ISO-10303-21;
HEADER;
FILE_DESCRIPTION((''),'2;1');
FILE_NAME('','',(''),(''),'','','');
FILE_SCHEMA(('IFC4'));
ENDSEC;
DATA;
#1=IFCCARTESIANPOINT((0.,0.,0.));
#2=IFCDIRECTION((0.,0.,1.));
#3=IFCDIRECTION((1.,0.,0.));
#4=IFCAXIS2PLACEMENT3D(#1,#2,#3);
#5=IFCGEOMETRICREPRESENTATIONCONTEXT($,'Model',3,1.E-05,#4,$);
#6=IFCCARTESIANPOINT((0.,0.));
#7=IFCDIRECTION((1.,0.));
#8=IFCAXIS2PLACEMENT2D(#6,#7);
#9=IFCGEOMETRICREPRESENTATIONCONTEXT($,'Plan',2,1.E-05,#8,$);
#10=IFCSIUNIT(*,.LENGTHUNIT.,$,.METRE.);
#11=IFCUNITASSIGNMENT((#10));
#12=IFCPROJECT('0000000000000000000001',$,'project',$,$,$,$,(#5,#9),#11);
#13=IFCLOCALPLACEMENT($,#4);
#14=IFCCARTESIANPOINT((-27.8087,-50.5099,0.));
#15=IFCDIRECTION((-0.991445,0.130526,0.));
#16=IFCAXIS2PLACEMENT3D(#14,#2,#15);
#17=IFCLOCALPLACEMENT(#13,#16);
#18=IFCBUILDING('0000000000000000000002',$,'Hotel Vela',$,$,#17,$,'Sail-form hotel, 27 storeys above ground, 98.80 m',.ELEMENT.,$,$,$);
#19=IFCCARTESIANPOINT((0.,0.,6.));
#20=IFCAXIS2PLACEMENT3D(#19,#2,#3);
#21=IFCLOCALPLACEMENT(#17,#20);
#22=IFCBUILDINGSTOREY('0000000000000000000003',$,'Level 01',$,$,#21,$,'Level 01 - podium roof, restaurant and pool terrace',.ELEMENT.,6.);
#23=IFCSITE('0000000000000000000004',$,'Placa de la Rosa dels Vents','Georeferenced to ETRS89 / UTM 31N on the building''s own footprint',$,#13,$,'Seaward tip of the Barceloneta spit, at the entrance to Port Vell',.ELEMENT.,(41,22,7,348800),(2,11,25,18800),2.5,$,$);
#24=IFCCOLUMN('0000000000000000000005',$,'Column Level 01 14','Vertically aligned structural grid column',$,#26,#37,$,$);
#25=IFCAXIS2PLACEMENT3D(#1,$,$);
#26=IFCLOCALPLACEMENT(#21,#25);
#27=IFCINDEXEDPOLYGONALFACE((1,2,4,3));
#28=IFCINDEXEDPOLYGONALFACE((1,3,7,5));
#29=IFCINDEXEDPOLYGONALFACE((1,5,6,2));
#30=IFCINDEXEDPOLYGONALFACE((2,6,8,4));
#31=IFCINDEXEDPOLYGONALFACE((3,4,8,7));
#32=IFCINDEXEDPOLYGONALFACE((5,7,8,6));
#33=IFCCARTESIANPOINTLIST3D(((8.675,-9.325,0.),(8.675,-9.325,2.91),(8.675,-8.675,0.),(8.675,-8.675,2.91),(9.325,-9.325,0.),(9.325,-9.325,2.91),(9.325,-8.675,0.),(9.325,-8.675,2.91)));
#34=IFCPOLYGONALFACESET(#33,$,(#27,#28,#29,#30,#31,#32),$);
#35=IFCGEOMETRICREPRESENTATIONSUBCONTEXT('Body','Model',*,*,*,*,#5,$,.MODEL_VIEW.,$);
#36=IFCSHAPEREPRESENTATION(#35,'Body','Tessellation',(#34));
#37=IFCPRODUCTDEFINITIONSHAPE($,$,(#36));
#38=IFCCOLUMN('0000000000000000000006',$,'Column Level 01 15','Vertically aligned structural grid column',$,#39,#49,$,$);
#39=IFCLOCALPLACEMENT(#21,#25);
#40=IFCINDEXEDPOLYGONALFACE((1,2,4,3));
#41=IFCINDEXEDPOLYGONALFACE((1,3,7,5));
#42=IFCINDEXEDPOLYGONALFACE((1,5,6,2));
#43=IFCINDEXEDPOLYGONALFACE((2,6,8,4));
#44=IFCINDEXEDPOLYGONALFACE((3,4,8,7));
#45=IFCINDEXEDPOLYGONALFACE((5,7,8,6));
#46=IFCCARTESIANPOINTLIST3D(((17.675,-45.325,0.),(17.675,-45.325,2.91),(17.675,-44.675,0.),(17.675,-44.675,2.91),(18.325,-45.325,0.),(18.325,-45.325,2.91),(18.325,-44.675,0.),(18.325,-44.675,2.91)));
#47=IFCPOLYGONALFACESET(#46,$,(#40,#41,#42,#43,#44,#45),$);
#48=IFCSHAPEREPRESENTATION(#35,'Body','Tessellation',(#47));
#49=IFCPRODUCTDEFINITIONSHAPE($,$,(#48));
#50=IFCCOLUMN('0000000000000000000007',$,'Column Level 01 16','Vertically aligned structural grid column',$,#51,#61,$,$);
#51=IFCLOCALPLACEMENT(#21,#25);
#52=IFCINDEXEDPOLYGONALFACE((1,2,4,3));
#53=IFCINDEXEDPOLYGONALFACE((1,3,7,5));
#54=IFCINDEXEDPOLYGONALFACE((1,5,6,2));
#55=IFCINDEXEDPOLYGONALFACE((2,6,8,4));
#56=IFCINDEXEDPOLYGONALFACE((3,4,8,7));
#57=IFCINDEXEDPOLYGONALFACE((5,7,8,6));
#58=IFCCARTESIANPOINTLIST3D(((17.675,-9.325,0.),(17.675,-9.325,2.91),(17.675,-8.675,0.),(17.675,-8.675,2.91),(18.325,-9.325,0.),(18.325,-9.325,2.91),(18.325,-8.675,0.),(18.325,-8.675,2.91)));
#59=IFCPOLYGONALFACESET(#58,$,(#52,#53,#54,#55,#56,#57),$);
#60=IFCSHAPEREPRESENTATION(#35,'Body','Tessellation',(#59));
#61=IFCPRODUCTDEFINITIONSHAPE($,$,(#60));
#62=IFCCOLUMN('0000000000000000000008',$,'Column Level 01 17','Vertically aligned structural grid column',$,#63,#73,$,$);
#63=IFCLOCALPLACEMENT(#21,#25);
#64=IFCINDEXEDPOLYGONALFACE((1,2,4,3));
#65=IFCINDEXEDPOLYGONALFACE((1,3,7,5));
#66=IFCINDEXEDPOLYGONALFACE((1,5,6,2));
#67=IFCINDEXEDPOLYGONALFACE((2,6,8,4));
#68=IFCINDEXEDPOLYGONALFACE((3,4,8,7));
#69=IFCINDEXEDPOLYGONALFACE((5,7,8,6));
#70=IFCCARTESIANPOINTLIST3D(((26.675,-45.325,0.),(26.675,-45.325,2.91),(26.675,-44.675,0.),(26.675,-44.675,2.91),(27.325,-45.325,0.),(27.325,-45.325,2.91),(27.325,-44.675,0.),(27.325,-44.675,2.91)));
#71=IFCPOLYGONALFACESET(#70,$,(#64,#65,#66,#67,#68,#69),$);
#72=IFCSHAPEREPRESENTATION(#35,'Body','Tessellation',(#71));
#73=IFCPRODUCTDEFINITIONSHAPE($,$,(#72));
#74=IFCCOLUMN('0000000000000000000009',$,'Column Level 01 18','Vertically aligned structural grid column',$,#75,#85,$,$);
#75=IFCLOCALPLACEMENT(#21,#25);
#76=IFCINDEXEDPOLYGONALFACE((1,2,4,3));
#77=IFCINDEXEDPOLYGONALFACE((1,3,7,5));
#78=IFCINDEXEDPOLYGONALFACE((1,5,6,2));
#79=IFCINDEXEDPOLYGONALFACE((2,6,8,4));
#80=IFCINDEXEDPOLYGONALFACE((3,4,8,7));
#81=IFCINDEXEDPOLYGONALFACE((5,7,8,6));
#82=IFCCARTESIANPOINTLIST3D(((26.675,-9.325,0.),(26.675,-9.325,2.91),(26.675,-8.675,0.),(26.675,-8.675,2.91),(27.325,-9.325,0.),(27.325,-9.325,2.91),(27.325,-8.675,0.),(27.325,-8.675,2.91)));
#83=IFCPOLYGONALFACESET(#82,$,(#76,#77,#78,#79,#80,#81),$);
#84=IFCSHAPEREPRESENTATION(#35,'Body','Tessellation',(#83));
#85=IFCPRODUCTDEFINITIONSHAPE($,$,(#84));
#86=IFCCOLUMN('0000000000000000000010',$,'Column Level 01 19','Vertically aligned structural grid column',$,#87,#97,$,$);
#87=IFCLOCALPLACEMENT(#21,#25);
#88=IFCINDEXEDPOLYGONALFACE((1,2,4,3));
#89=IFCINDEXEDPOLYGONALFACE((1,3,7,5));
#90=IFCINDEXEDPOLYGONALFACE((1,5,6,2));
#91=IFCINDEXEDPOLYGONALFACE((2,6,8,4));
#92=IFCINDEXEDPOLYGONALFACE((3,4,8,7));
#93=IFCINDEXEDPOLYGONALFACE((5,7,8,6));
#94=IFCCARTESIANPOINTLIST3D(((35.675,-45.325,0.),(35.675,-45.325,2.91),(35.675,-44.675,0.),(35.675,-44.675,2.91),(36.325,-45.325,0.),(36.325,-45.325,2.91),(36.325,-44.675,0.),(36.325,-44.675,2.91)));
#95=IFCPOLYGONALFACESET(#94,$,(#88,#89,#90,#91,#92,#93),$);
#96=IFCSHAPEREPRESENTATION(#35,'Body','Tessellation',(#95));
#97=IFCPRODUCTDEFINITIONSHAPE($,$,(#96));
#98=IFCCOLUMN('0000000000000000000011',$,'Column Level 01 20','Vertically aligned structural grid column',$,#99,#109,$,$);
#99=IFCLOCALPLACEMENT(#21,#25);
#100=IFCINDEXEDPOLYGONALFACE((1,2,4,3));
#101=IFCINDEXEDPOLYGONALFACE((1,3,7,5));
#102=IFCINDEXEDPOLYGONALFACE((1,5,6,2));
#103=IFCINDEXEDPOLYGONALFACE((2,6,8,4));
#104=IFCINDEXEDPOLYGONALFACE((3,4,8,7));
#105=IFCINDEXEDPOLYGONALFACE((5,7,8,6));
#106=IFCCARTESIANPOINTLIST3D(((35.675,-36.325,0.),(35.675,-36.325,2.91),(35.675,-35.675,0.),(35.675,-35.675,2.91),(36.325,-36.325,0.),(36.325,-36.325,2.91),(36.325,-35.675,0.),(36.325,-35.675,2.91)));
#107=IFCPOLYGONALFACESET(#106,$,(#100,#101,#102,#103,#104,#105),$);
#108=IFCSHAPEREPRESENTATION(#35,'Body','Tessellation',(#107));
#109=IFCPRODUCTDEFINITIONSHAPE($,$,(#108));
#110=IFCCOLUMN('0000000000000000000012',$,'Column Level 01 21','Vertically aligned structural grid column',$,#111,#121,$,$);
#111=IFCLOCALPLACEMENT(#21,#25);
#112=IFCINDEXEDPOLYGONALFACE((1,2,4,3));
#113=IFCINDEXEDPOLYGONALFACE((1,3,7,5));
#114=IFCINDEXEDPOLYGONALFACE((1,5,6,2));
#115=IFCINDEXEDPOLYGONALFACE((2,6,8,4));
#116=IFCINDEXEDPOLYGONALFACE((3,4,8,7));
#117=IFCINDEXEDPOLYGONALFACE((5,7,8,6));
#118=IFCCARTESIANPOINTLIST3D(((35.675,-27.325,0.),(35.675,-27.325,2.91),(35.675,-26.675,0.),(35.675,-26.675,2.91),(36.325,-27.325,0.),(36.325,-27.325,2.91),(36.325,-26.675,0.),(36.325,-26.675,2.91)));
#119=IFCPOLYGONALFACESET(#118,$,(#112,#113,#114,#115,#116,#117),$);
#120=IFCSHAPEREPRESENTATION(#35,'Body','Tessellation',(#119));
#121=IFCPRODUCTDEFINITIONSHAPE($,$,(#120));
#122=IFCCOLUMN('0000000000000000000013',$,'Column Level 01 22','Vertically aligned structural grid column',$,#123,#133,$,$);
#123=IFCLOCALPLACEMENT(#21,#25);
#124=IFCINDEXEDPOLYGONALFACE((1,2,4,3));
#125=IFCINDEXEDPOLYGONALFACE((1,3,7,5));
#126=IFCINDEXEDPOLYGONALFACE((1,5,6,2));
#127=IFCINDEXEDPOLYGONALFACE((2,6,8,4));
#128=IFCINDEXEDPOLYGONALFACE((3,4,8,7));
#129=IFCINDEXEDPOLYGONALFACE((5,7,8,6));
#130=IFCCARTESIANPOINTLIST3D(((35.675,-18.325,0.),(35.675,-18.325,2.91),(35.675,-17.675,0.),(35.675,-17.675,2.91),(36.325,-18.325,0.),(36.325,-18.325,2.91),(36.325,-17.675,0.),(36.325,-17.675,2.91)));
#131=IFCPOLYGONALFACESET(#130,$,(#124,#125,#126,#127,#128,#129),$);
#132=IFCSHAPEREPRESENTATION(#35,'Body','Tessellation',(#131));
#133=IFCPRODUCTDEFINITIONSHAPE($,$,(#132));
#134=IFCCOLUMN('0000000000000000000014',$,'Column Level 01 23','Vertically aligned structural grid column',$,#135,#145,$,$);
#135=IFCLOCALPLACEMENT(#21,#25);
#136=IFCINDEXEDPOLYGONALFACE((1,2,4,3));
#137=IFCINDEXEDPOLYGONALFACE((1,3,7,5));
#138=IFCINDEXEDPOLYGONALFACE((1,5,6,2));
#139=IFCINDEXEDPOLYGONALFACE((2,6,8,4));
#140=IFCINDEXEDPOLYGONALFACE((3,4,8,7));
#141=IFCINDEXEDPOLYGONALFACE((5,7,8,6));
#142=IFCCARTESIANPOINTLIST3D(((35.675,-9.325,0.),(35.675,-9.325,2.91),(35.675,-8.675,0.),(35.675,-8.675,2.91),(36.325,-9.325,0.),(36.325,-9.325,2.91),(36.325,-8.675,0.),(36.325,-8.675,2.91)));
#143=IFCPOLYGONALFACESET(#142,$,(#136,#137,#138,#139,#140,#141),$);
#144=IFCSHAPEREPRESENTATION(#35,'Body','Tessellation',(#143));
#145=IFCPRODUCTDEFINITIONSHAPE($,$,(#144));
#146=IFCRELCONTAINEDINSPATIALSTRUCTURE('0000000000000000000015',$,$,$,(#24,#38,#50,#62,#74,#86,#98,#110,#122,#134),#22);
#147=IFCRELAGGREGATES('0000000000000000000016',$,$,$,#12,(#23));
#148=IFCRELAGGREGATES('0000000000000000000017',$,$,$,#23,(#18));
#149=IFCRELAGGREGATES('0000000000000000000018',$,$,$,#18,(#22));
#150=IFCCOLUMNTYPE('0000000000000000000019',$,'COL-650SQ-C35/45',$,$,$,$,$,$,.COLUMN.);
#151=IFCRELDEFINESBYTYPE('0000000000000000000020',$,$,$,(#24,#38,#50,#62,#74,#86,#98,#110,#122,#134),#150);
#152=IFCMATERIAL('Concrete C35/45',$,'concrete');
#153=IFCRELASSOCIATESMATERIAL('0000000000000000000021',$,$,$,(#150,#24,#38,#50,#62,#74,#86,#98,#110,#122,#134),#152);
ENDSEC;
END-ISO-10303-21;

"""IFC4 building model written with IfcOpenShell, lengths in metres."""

from ifc_helpers import new_model, si_unit, frame, origin_with_axes, origin_2d_with_axis, place, context, subcontext, project, spatial, line, indexed_curve, rectangle, outline, extrude, material, material_profile, profile_set, profile_usage, type_object, element, save


model = new_model("IFC4")

# Units and contexts
model_context = context("Model", 3, precision=1e-05, world=origin_with_axes())
plan_context = context("Plan", 2, precision=1e-05, world=origin_2d_with_axis())
body_context = subcontext(model_context, "Body", "Model", "MODEL_VIEW")
ifc_project = project(units=[si_unit("LENGTHUNIT", "METRE")], contexts=[model_context, plan_context])

# Site, building, storey
site_placement = place(None, origin_with_axes())
site = spatial("IfcSite", under=ifc_project, at=site_placement, Name="Placa de la Rosa dels Vents", Description="Georeferenced to ETRS89 / UTM 31N on the building's own footprint", LongName="Seaward tip of the Barceloneta spit, at the entrance to Port Vell", CompositionType="ELEMENT", RefLatitude=(41, 22, 7, 348800), RefLongitude=(2, 11, 25, 18800), RefElevation=2.5)
building_placement = place(site_placement, frame((-27.8087, -50.5099, 0.0), z_axis=(0.0, 0.0, 1.0), x_axis=(-0.991445, 0.130526, 0.0)))
building = spatial("IfcBuilding", under=site, at=building_placement, Name="Hotel Vela", LongName="Sail-form hotel, 27 storeys above ground, 98.80 m", CompositionType="ELEMENT")
storey_placement = place(building_placement, frame((0.0, 0.0, 6.0), z_axis=(0.0, 0.0, 1.0), x_axis=(1.0, 0.0, 0.0)))
storey = spatial("IfcBuildingStorey", under=building, at=storey_placement, Name="Level 01", LongName="Level 01 - podium roof, restaurant and pool terrace", CompositionType="ELEMENT", Elevation=6.0)

# Columns
ifc_material = material(Name="Concrete C35/45", Category="concrete")
ifc_material_profile = material_profile(ifc_material, rectangle(XDim=0.65, YDim=0.65))
ifc_profile_set = profile_set([ifc_material_profile], Name="COL-650SQ-C35/45")
column_type = type_object("IfcColumnType", Name="COL-650SQ-C35/45", PredefinedType="COLUMN", material=ifc_profile_set)
ifc_profile_usage_1 = profile_usage(ifc_profile_set)
column_1_placement = place(storey_placement, frame((8.675, -9.325, 0.0), z_axis=(0.0, 0.0, 1.0), x_axis=(1.0, 0.0, 0.0)))
element("IfcColumn", 1, at=column_1_placement, inside=storey, type_object=column_type, material=ifc_profile_usage_1, Name="Column Level 01 14", Description="Vertically aligned structural grid column", context=body_context, shape_type="SweptSolid", body=[
    extrude(outline(indexed_curve([(0.0, 0.0), (0.65, 0.0), (0.65, 0.65), (0.0, 0.65)], segments=[line(1, 2, 3, 4, 1)])), origin_with_axes(), (0.0, 0.0, 1.0), 2.91),
])
ifc_profile_usage_2 = profile_usage(ifc_profile_set)
column_2_placement = place(storey_placement, frame((17.675, -45.325, 0.0), z_axis=(0.0, 0.0, 1.0), x_axis=(1.0, 0.0, 0.0)))
element("IfcColumn", 2, at=column_2_placement, inside=storey, type_object=column_type, material=ifc_profile_usage_2, Name="Column Level 01 15", Description="Vertically aligned structural grid column", context=body_context, shape_type="SweptSolid", body=[
    extrude(outline(indexed_curve([(0.0, 0.0), (0.65, 0.0), (0.65, 0.65), (0.0, 0.65)], segments=[line(1, 2, 3, 4, 1)])), origin_with_axes(), (0.0, 0.0, 1.0), 2.91),
])
ifc_profile_usage_3 = profile_usage(ifc_profile_set)
column_3_placement = place(storey_placement, frame((17.675, -9.325, 0.0), z_axis=(0.0, 0.0, 1.0), x_axis=(1.0, 0.0, 0.0)))
element("IfcColumn", 3, at=column_3_placement, inside=storey, type_object=column_type, material=ifc_profile_usage_3, Name="Column Level 01 16", Description="Vertically aligned structural grid column", context=body_context, shape_type="SweptSolid", body=[
    extrude(outline(indexed_curve([(0.0, 0.0), (0.65, 0.0), (0.65, 0.65), (0.0, 0.65)], segments=[line(1, 2, 3, 4, 1)])), origin_with_axes(), (0.0, 0.0, 1.0), 2.91),
])
ifc_profile_usage_4 = profile_usage(ifc_profile_set)
column_4_placement = place(storey_placement, frame((26.675, -45.325, 0.0), z_axis=(0.0, 0.0, 1.0), x_axis=(1.0, 0.0, 0.0)))
element("IfcColumn", 4, at=column_4_placement, inside=storey, type_object=column_type, material=ifc_profile_usage_4, Name="Column Level 01 17", Description="Vertically aligned structural grid column", context=body_context, shape_type="SweptSolid", body=[
    extrude(outline(indexed_curve([(0.0, 0.0), (0.65, 0.0), (0.65, 0.65), (0.0, 0.65)], segments=[line(1, 2, 3, 4, 1)])), origin_with_axes(), (0.0, 0.0, 1.0), 2.91),
])
ifc_profile_usage_5 = profile_usage(ifc_profile_set)
column_5_placement = place(storey_placement, frame((26.675, -9.325, 0.0), z_axis=(0.0, 0.0, 1.0), x_axis=(1.0, 0.0, 0.0)))
element("IfcColumn", 5, at=column_5_placement, inside=storey, type_object=column_type, material=ifc_profile_usage_5, Name="Column Level 01 18", Description="Vertically aligned structural grid column", context=body_context, shape_type="SweptSolid", body=[
    extrude(outline(indexed_curve([(0.0, 0.0), (0.65, 0.0), (0.65, 0.65), (0.0, 0.65)], segments=[line(1, 2, 3, 4, 1)])), origin_with_axes(), (0.0, 0.0, 1.0), 2.91),
])
ifc_profile_usage_6 = profile_usage(ifc_profile_set)
column_6_placement = place(storey_placement, frame((35.675, -45.325, 0.0), z_axis=(0.0, 0.0, 1.0), x_axis=(1.0, 0.0, 0.0)))
element("IfcColumn", 6, at=column_6_placement, inside=storey, type_object=column_type, material=ifc_profile_usage_6, Name="Column Level 01 19", Description="Vertically aligned structural grid column", context=body_context, shape_type="SweptSolid", body=[
    extrude(outline(indexed_curve([(0.0, 0.0), (0.65, 0.0), (0.65, 0.65), (0.0, 0.65)], segments=[line(1, 2, 3, 4, 1)])), origin_with_axes(), (0.0, 0.0, 1.0), 2.91),
])
ifc_profile_usage_7 = profile_usage(ifc_profile_set)
column_7_placement = place(storey_placement, frame((35.675, -36.325, 0.0), z_axis=(0.0, 0.0, 1.0), x_axis=(1.0, 0.0, 0.0)))
element("IfcColumn", 7, at=column_7_placement, inside=storey, type_object=column_type, material=ifc_profile_usage_7, Name="Column Level 01 20", Description="Vertically aligned structural grid column", context=body_context, shape_type="SweptSolid", body=[
    extrude(outline(indexed_curve([(0.0, 0.0), (0.65, 0.0), (0.65, 0.65), (0.0, 0.65)], segments=[line(1, 2, 3, 4, 1)])), origin_with_axes(), (0.0, 0.0, 1.0), 2.91),
])
ifc_profile_usage_8 = profile_usage(ifc_profile_set)
column_8_placement = place(storey_placement, frame((35.675, -27.325, 0.0), z_axis=(0.0, 0.0, 1.0), x_axis=(1.0, 0.0, 0.0)))
element("IfcColumn", 8, at=column_8_placement, inside=storey, type_object=column_type, material=ifc_profile_usage_8, Name="Column Level 01 21", Description="Vertically aligned structural grid column", context=body_context, shape_type="SweptSolid", body=[
    extrude(outline(indexed_curve([(0.0, 0.0), (0.65, 0.0), (0.65, 0.65), (0.0, 0.65)], segments=[line(1, 2, 3, 4, 1)])), origin_with_axes(), (0.0, 0.0, 1.0), 2.91),
])
ifc_profile_usage_9 = profile_usage(ifc_profile_set)
column_9_placement = place(storey_placement, frame((35.675, -18.325, 0.0), z_axis=(0.0, 0.0, 1.0), x_axis=(1.0, 0.0, 0.0)))
element("IfcColumn", 9, at=column_9_placement, inside=storey, type_object=column_type, material=ifc_profile_usage_9, Name="Column Level 01 22", Description="Vertically aligned structural grid column", context=body_context, shape_type="SweptSolid", body=[
    extrude(outline(indexed_curve([(0.0, 0.0), (0.65, 0.0), (0.65, 0.65), (0.0, 0.65)], segments=[line(1, 2, 3, 4, 1)])), origin_with_axes(), (0.0, 0.0, 1.0), 2.91),
])
ifc_profile_usage_10 = profile_usage(ifc_profile_set)
column_10_placement = place(storey_placement, frame((35.675, -9.325, 0.0), z_axis=(0.0, 0.0, 1.0), x_axis=(1.0, 0.0, 0.0)))
element("IfcColumn", 10, at=column_10_placement, inside=storey, type_object=column_type, material=ifc_profile_usage_10, Name="Column Level 01 23", Description="Vertically aligned structural grid column", context=body_context, shape_type="SweptSolid", body=[
    extrude(outline(indexed_curve([(0.0, 0.0), (0.65, 0.0), (0.65, 0.65), (0.0, 0.65)], segments=[line(1, 2, 3, 4, 1)])), origin_with_axes(), (0.0, 0.0, 1.0), 2.91),
])

save(model, "model.ifc")
